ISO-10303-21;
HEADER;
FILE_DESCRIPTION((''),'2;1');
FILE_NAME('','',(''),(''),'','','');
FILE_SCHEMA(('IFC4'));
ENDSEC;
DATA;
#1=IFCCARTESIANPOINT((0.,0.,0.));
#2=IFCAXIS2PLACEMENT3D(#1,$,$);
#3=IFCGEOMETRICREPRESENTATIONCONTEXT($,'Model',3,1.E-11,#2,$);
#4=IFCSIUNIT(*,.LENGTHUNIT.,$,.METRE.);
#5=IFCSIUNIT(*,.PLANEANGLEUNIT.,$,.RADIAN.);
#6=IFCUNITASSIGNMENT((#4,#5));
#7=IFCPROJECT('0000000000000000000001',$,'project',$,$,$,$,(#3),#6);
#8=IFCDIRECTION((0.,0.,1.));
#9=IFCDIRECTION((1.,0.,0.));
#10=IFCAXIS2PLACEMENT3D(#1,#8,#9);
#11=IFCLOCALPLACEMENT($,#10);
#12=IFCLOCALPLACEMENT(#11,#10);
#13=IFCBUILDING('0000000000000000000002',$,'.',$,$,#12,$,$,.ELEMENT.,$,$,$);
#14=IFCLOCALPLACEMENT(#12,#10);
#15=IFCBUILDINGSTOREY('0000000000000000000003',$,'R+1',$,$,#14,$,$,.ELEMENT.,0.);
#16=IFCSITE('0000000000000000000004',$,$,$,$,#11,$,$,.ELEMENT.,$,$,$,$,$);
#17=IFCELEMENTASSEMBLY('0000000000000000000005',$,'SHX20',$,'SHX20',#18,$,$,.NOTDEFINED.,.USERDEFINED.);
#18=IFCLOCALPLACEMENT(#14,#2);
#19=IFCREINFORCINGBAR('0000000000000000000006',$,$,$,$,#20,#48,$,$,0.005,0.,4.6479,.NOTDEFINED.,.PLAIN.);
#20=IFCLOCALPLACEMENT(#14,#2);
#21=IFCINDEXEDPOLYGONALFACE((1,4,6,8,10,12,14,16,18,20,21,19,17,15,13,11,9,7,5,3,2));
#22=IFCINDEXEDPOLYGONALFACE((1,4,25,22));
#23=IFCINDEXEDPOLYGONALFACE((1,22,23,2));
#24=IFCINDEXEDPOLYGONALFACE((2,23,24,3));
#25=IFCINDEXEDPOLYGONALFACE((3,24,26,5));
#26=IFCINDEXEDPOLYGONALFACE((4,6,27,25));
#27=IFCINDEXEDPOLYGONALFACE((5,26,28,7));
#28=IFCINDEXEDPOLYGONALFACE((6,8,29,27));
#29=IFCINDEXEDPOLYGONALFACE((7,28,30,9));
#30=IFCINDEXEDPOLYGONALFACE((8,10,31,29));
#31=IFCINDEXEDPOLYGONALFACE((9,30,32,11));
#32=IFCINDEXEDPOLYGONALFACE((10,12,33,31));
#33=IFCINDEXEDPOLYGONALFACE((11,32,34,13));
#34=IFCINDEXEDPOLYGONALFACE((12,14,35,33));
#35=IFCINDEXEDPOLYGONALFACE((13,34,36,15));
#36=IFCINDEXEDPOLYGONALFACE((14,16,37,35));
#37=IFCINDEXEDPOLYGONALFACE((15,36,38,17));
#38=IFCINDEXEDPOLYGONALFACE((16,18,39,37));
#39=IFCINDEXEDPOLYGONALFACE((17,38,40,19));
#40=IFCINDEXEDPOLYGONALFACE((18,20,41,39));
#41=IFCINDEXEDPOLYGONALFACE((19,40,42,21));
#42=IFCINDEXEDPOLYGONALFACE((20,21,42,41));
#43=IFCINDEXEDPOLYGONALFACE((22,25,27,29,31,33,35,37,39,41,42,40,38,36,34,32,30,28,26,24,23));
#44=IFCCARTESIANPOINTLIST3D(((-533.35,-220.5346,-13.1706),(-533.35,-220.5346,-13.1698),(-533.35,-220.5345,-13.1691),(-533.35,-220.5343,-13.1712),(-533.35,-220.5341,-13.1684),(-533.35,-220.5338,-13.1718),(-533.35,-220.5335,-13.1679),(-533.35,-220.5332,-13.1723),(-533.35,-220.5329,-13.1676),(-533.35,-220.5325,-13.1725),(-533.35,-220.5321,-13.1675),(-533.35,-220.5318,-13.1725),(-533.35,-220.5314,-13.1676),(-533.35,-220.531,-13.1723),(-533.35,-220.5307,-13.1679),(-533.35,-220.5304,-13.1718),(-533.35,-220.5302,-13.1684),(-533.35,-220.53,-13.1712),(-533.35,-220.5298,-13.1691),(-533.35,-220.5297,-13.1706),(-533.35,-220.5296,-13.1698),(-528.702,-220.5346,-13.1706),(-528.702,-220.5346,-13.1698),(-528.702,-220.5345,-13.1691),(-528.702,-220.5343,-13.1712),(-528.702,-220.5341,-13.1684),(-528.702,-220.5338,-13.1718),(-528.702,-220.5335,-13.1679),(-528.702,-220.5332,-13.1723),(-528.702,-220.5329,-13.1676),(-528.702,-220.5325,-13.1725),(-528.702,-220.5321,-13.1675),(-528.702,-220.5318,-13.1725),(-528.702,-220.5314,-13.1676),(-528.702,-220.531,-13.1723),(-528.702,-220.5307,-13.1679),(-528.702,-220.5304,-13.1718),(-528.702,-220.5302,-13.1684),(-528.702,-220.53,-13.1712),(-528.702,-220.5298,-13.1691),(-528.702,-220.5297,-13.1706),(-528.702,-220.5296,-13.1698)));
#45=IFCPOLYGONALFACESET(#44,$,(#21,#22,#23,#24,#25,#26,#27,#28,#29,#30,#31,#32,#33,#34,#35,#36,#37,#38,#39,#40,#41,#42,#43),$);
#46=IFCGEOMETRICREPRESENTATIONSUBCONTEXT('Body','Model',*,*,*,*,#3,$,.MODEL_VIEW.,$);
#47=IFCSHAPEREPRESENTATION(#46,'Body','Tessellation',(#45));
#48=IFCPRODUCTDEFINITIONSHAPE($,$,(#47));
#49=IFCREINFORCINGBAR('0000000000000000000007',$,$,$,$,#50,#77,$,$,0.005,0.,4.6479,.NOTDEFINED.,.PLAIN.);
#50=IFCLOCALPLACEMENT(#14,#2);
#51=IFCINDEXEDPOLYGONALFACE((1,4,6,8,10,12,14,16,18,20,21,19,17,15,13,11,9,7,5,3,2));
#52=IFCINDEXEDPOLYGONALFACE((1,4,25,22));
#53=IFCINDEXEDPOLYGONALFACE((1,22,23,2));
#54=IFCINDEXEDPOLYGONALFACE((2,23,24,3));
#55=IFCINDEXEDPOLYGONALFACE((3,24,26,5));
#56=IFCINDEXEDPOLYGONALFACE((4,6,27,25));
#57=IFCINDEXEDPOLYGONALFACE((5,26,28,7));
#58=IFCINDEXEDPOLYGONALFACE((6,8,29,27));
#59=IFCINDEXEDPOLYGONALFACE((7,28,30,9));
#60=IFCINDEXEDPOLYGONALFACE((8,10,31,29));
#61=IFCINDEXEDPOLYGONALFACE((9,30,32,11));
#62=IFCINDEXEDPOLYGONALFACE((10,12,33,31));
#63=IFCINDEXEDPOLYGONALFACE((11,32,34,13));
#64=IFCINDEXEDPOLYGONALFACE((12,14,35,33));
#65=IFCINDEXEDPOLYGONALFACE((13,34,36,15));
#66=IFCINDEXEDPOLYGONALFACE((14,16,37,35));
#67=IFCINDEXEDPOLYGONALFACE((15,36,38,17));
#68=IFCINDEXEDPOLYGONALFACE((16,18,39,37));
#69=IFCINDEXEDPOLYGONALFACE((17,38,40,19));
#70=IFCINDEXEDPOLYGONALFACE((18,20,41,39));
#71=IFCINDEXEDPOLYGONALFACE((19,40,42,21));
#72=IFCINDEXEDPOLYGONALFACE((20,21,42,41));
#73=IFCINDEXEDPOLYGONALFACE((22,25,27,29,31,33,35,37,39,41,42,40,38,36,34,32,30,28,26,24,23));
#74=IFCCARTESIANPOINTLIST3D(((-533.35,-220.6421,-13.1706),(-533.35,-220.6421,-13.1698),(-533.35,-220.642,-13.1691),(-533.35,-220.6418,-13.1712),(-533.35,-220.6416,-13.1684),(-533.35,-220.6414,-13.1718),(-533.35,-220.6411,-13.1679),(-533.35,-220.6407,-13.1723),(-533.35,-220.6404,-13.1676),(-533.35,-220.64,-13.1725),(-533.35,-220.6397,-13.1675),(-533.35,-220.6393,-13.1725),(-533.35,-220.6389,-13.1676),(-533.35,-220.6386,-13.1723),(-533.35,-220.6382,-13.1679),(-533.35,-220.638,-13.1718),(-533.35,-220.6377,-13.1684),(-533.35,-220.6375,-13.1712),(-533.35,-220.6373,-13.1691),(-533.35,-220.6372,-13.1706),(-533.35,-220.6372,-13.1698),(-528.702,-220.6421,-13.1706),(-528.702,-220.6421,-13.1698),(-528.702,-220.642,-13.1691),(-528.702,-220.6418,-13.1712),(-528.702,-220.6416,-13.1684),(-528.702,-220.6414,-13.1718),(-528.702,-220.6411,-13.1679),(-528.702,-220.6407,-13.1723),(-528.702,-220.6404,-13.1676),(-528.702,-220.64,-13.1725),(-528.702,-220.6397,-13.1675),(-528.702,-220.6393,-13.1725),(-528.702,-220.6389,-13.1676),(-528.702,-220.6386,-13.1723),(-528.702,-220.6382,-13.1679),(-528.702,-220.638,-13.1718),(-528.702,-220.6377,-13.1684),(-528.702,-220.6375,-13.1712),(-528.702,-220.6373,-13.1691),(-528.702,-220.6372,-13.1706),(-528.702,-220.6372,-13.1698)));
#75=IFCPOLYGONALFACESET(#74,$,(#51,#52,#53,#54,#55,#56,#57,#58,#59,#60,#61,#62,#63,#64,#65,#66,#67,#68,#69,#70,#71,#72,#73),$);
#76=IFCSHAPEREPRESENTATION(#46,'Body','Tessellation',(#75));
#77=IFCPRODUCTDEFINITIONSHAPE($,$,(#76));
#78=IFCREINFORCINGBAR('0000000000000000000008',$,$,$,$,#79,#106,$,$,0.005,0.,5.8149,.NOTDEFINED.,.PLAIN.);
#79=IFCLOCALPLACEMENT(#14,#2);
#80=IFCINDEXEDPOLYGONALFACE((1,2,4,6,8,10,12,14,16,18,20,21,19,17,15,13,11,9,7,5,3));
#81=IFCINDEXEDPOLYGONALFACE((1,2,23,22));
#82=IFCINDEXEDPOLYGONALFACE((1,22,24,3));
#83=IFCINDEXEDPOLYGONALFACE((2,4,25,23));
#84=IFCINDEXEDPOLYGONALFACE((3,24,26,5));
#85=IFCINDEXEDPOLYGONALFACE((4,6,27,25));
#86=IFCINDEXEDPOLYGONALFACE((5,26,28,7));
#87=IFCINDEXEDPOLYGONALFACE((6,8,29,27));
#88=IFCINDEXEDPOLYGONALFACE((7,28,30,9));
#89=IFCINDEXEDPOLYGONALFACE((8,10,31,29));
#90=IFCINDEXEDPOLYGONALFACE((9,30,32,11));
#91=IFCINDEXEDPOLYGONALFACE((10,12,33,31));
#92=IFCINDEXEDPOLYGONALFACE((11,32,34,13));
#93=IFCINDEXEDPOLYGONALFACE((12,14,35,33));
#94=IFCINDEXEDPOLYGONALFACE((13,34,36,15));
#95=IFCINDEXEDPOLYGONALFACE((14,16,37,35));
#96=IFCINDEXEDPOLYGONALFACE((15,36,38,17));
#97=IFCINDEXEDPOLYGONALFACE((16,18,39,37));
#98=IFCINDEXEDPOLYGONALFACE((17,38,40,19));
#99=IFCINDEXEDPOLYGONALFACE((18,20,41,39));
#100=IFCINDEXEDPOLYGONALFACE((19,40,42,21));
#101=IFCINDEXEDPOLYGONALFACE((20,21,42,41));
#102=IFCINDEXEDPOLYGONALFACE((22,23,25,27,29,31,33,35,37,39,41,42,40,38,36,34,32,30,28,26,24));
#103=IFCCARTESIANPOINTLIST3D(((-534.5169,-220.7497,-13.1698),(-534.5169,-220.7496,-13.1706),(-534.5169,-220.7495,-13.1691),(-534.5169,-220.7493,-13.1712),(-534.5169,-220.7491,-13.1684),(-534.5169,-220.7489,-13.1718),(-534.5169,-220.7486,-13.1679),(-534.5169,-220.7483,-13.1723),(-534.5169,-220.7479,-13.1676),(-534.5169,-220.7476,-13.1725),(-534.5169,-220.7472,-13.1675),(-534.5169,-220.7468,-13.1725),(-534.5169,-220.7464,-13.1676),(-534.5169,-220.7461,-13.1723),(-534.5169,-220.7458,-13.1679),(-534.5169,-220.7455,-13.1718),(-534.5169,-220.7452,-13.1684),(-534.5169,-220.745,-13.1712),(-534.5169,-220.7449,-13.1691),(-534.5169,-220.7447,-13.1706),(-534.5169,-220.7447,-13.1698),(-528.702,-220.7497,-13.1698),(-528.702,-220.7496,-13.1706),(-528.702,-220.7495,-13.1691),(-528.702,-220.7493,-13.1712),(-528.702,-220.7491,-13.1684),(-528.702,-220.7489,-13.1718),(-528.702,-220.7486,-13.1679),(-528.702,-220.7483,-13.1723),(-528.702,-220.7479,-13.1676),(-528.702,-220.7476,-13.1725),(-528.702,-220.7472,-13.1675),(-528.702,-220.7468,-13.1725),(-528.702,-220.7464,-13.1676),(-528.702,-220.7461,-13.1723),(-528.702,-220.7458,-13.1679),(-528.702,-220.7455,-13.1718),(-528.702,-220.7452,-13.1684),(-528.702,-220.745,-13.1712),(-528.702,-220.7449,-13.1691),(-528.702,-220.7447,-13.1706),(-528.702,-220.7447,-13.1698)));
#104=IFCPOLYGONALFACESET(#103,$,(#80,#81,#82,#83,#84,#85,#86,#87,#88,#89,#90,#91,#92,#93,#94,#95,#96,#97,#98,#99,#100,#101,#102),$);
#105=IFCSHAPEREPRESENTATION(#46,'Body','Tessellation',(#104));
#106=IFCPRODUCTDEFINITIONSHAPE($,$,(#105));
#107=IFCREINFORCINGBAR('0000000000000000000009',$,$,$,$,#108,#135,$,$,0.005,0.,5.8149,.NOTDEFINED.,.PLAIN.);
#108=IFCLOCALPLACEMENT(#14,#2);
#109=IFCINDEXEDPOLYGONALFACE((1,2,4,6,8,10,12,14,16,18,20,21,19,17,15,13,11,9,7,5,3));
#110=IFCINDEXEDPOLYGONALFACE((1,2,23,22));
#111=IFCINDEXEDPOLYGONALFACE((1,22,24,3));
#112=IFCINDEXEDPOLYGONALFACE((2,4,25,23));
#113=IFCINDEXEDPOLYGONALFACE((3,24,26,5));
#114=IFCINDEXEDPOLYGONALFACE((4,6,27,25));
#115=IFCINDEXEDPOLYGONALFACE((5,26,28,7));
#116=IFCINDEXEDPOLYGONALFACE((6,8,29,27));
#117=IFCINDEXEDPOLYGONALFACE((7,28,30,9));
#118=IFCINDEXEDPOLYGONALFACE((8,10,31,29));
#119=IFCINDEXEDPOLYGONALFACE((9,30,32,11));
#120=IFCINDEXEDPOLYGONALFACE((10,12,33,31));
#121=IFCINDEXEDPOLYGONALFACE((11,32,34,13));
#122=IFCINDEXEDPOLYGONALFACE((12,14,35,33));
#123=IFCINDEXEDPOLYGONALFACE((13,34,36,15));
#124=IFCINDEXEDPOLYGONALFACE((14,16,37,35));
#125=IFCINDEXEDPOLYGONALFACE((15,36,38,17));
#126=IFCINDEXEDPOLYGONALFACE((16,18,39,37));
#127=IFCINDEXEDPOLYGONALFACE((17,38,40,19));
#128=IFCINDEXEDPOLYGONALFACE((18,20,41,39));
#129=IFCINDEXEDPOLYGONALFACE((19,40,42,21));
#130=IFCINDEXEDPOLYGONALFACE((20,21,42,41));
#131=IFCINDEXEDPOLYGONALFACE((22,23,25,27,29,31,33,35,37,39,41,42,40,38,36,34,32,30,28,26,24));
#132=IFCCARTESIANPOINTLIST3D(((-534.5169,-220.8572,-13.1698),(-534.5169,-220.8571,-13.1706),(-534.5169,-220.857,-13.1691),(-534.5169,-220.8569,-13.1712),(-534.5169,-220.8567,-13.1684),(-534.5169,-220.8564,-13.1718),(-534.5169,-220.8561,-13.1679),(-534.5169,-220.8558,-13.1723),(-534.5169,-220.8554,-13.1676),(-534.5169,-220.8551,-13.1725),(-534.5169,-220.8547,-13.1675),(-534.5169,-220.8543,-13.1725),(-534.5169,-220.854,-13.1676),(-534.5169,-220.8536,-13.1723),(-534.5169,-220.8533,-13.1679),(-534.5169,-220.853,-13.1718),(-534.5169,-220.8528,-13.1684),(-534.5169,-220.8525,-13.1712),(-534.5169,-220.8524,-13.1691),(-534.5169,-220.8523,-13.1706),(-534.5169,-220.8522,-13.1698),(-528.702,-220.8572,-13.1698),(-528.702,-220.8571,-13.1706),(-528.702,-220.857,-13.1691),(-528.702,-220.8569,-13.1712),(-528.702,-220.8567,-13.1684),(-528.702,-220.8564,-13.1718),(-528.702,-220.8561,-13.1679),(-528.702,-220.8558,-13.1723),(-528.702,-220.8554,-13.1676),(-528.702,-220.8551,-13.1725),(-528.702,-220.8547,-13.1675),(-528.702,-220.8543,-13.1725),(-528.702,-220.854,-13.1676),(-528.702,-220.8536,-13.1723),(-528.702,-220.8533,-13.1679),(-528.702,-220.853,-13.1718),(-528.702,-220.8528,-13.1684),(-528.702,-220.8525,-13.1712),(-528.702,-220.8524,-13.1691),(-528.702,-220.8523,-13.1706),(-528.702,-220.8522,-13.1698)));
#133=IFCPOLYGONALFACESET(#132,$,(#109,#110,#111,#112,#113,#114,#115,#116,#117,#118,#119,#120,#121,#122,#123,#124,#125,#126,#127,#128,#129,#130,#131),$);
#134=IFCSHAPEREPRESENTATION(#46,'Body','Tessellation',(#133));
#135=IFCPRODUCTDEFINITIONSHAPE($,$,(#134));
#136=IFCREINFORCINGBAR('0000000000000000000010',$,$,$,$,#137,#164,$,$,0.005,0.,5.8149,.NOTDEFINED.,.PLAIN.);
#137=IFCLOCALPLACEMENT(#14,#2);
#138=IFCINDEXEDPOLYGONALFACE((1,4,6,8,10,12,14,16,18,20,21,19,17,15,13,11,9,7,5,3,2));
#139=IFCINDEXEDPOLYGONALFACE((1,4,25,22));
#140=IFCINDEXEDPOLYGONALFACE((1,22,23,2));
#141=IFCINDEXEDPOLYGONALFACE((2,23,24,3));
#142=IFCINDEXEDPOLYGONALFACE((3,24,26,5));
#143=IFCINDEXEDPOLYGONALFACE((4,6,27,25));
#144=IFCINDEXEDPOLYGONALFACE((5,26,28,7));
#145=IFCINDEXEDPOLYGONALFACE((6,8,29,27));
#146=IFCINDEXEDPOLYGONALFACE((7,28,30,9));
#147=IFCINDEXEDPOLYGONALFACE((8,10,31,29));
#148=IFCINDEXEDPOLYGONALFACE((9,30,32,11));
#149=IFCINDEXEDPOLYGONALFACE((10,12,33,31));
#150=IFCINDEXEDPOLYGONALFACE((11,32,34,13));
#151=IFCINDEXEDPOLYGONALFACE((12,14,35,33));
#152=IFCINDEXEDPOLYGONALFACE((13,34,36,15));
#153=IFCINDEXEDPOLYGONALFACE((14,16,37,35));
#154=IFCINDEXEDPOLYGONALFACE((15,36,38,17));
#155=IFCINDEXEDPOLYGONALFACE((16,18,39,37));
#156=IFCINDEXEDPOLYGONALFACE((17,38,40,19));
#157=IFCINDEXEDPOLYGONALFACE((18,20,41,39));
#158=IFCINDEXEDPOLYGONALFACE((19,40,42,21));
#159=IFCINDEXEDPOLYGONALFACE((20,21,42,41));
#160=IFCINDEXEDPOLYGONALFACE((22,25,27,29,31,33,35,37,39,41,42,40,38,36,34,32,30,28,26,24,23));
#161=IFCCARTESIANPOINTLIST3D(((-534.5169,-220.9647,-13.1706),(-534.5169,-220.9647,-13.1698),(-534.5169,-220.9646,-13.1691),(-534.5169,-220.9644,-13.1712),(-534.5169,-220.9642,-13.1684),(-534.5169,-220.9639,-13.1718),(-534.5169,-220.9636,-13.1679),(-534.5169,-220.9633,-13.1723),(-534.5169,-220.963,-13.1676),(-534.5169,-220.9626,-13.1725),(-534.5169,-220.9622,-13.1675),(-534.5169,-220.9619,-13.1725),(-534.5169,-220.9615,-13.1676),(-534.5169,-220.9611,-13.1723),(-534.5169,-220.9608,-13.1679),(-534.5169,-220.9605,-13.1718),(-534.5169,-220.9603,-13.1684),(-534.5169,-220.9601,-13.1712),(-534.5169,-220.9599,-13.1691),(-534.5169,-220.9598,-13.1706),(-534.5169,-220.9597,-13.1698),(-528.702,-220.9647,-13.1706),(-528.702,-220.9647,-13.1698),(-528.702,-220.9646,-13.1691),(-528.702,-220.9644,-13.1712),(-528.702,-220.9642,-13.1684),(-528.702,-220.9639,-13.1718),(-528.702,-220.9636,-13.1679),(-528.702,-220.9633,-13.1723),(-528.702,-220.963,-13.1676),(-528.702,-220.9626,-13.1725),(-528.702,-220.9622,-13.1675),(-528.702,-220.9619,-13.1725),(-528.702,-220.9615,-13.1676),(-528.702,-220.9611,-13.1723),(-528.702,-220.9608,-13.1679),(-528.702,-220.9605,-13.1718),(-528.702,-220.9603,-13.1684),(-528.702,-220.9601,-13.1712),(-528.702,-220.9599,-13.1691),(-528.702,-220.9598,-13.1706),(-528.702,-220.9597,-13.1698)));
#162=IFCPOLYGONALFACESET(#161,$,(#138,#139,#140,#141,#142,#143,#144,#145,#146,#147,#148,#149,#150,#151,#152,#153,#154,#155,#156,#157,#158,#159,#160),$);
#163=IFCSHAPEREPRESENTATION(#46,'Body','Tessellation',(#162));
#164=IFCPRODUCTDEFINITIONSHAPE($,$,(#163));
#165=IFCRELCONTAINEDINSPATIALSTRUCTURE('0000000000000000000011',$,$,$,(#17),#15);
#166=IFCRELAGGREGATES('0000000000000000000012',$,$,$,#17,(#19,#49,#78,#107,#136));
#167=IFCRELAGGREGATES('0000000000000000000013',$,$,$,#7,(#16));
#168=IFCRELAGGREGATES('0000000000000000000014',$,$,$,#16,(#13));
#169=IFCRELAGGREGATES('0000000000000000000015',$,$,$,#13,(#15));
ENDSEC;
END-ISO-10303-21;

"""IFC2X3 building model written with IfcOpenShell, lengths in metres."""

from ifc_helpers import new_model, entity, si_unit, origin, origin_with_axes, place, context, subcontext, project, spatial, shape, element, aggregate, save


model = new_model("IFC2X3")

# Units and contexts
model_context = context("Model", 3, precision=1e-11, world=origin())
body_context = subcontext(model_context, "Body", "Model", "MODEL_VIEW")
ifc_project = project(units=[si_unit("LENGTHUNIT", "METRE"), si_unit("PLANEANGLEUNIT", "RADIAN")], contexts=[model_context])

# Site, building, storey
site_placement = place(None, origin_with_axes())
site = spatial("IfcSite", under=ifc_project, at=site_placement, CompositionType="ELEMENT")
building_placement = place(site_placement, origin_with_axes())
building = spatial("IfcBuilding", under=site, at=building_placement, Name=".", CompositionType="ELEMENT")
storey_placement = place(building_placement, origin_with_axes())
storey = spatial("IfcBuildingStorey", under=building, at=storey_placement, Name="R+1", CompositionType="ELEMENT", Elevation=0.0)

# Element assembly, reinforcing bars
assembly_1_placement = place(storey_placement, origin_with_axes())
assembly_1 = element("IfcElementAssembly", 1, at=assembly_1_placement, inside=storey, Name="SHX20", ObjectType="SHX20", AssemblyPlace="NOTDEFINED", PredefinedType="USERDEFINED")
reinforcing_bar_1_placement = place(assembly_1_placement, origin_with_axes())
reinforcing_bar_1 = element("IfcReinforcingBar", 2, at=reinforcing_bar_1_placement, BarLength=4.6479, BarRole="NOTDEFINED", BarSurface="PLAIN", CrossSectionArea=0.0, NominalDiameter=0.005, shapes=[
    shape(body_context, "Body", "AdvancedSweptSolid", [entity("IfcSweptDiskSolid", entity("IfcPolyline", [entity("IfcCartesianPoint", [528.702, 220.5321, 13.17]), entity("IfcCartesianPoint", [533.35, 220.5321, 13.17])]), 0.0025, None, 0.0, 4.6479)]),
    shape(body_context, "Body", "AdvancedSweptSolid", [entity("IfcSweptDiskSolid", entity("IfcPolyline", [entity("IfcCartesianPoint", [528.702, 220.5321, 13.17]), entity("IfcCartesianPoint", [533.35, 220.5321, 13.17])]), 0.0025, None, 0.0, 4.6479)]),
])
reinforcing_bar_2_placement = place(assembly_1_placement, origin_with_axes())
reinforcing_bar_2 = element("IfcReinforcingBar", 3, at=reinforcing_bar_2_placement, BarLength=4.6479, BarRole="NOTDEFINED", BarSurface="PLAIN", CrossSectionArea=0.0, NominalDiameter=0.005, shapes=[
    shape(body_context, "Body", "AdvancedSweptSolid", [entity("IfcSweptDiskSolid", entity("IfcPolyline", [entity("IfcCartesianPoint", [528.702, 220.6397, 13.17]), entity("IfcCartesianPoint", [533.35, 220.6397, 13.17])]), 0.0025, None, 0.0, 4.6479)]),
    shape(body_context, "Body", "AdvancedSweptSolid", [entity("IfcSweptDiskSolid", entity("IfcPolyline", [entity("IfcCartesianPoint", [528.702, 220.6397, 13.17]), entity("IfcCartesianPoint", [533.35, 220.6397, 13.17])]), 0.0025, None, 0.0, 4.6479)]),
])
reinforcing_bar_3_placement = place(assembly_1_placement, origin_with_axes())
reinforcing_bar_3 = element("IfcReinforcingBar", 4, at=reinforcing_bar_3_placement, BarLength=5.8149, BarRole="NOTDEFINED", BarSurface="PLAIN", CrossSectionArea=0.0, NominalDiameter=0.005, shapes=[
    shape(body_context, "Body", "AdvancedSweptSolid", [entity("IfcSweptDiskSolid", entity("IfcPolyline", [entity("IfcCartesianPoint", [528.702, 220.7472, 13.17]), entity("IfcCartesianPoint", [534.5169, 220.7472, 13.17])]), 0.0025, None, 0.0, 5.8149)]),
    shape(body_context, "Body", "AdvancedSweptSolid", [entity("IfcSweptDiskSolid", entity("IfcPolyline", [entity("IfcCartesianPoint", [528.702, 220.7472, 13.17]), entity("IfcCartesianPoint", [534.5169, 220.7472, 13.17])]), 0.0025, None, 0.0, 5.8149)]),
])
reinforcing_bar_4_placement = place(assembly_1_placement, origin_with_axes())
reinforcing_bar_4 = element("IfcReinforcingBar", 5, at=reinforcing_bar_4_placement, BarLength=5.8149, BarRole="NOTDEFINED", BarSurface="PLAIN", CrossSectionArea=0.0, NominalDiameter=0.005, shapes=[
    shape(body_context, "Body", "AdvancedSweptSolid", [entity("IfcSweptDiskSolid", entity("IfcPolyline", [entity("IfcCartesianPoint", [528.702, 220.8547, 13.17]), entity("IfcCartesianPoint", [534.5169, 220.8547, 13.17])]), 0.0025, None, 0.0, 5.8149)]),
    shape(body_context, "Body", "AdvancedSweptSolid", [entity("IfcSweptDiskSolid", entity("IfcPolyline", [entity("IfcCartesianPoint", [528.702, 220.8547, 13.17]), entity("IfcCartesianPoint", [534.5169, 220.8547, 13.17])]), 0.0025, None, 0.0, 5.8149)]),
])
reinforcing_bar_5_placement = place(assembly_1_placement, origin_with_axes())
reinforcing_bar_5 = element("IfcReinforcingBar", 6, at=reinforcing_bar_5_placement, BarLength=5.8149, BarRole="NOTDEFINED", BarSurface="PLAIN", CrossSectionArea=0.0, NominalDiameter=0.005, shapes=[
    shape(body_context, "Body", "AdvancedSweptSolid", [entity("IfcSweptDiskSolid", entity("IfcPolyline", [entity("IfcCartesianPoint", [528.702, 220.9622, 13.17]), entity("IfcCartesianPoint", [534.5169, 220.9622, 13.17])]), 0.0025, None, 0.0, 5.8149)]),
    shape(body_context, "Body", "AdvancedSweptSolid", [entity("IfcSweptDiskSolid", entity("IfcPolyline", [entity("IfcCartesianPoint", [528.702, 220.9622, 13.17]), entity("IfcCartesianPoint", [534.5169, 220.9622, 13.17])]), 0.0025, None, 0.0, 5.8149)]),
])
aggregate(assembly_1, [reinforcing_bar_1, reinforcing_bar_2, reinforcing_bar_3, reinforcing_bar_4, reinforcing_bar_5])

save(model, "model.ifc")
